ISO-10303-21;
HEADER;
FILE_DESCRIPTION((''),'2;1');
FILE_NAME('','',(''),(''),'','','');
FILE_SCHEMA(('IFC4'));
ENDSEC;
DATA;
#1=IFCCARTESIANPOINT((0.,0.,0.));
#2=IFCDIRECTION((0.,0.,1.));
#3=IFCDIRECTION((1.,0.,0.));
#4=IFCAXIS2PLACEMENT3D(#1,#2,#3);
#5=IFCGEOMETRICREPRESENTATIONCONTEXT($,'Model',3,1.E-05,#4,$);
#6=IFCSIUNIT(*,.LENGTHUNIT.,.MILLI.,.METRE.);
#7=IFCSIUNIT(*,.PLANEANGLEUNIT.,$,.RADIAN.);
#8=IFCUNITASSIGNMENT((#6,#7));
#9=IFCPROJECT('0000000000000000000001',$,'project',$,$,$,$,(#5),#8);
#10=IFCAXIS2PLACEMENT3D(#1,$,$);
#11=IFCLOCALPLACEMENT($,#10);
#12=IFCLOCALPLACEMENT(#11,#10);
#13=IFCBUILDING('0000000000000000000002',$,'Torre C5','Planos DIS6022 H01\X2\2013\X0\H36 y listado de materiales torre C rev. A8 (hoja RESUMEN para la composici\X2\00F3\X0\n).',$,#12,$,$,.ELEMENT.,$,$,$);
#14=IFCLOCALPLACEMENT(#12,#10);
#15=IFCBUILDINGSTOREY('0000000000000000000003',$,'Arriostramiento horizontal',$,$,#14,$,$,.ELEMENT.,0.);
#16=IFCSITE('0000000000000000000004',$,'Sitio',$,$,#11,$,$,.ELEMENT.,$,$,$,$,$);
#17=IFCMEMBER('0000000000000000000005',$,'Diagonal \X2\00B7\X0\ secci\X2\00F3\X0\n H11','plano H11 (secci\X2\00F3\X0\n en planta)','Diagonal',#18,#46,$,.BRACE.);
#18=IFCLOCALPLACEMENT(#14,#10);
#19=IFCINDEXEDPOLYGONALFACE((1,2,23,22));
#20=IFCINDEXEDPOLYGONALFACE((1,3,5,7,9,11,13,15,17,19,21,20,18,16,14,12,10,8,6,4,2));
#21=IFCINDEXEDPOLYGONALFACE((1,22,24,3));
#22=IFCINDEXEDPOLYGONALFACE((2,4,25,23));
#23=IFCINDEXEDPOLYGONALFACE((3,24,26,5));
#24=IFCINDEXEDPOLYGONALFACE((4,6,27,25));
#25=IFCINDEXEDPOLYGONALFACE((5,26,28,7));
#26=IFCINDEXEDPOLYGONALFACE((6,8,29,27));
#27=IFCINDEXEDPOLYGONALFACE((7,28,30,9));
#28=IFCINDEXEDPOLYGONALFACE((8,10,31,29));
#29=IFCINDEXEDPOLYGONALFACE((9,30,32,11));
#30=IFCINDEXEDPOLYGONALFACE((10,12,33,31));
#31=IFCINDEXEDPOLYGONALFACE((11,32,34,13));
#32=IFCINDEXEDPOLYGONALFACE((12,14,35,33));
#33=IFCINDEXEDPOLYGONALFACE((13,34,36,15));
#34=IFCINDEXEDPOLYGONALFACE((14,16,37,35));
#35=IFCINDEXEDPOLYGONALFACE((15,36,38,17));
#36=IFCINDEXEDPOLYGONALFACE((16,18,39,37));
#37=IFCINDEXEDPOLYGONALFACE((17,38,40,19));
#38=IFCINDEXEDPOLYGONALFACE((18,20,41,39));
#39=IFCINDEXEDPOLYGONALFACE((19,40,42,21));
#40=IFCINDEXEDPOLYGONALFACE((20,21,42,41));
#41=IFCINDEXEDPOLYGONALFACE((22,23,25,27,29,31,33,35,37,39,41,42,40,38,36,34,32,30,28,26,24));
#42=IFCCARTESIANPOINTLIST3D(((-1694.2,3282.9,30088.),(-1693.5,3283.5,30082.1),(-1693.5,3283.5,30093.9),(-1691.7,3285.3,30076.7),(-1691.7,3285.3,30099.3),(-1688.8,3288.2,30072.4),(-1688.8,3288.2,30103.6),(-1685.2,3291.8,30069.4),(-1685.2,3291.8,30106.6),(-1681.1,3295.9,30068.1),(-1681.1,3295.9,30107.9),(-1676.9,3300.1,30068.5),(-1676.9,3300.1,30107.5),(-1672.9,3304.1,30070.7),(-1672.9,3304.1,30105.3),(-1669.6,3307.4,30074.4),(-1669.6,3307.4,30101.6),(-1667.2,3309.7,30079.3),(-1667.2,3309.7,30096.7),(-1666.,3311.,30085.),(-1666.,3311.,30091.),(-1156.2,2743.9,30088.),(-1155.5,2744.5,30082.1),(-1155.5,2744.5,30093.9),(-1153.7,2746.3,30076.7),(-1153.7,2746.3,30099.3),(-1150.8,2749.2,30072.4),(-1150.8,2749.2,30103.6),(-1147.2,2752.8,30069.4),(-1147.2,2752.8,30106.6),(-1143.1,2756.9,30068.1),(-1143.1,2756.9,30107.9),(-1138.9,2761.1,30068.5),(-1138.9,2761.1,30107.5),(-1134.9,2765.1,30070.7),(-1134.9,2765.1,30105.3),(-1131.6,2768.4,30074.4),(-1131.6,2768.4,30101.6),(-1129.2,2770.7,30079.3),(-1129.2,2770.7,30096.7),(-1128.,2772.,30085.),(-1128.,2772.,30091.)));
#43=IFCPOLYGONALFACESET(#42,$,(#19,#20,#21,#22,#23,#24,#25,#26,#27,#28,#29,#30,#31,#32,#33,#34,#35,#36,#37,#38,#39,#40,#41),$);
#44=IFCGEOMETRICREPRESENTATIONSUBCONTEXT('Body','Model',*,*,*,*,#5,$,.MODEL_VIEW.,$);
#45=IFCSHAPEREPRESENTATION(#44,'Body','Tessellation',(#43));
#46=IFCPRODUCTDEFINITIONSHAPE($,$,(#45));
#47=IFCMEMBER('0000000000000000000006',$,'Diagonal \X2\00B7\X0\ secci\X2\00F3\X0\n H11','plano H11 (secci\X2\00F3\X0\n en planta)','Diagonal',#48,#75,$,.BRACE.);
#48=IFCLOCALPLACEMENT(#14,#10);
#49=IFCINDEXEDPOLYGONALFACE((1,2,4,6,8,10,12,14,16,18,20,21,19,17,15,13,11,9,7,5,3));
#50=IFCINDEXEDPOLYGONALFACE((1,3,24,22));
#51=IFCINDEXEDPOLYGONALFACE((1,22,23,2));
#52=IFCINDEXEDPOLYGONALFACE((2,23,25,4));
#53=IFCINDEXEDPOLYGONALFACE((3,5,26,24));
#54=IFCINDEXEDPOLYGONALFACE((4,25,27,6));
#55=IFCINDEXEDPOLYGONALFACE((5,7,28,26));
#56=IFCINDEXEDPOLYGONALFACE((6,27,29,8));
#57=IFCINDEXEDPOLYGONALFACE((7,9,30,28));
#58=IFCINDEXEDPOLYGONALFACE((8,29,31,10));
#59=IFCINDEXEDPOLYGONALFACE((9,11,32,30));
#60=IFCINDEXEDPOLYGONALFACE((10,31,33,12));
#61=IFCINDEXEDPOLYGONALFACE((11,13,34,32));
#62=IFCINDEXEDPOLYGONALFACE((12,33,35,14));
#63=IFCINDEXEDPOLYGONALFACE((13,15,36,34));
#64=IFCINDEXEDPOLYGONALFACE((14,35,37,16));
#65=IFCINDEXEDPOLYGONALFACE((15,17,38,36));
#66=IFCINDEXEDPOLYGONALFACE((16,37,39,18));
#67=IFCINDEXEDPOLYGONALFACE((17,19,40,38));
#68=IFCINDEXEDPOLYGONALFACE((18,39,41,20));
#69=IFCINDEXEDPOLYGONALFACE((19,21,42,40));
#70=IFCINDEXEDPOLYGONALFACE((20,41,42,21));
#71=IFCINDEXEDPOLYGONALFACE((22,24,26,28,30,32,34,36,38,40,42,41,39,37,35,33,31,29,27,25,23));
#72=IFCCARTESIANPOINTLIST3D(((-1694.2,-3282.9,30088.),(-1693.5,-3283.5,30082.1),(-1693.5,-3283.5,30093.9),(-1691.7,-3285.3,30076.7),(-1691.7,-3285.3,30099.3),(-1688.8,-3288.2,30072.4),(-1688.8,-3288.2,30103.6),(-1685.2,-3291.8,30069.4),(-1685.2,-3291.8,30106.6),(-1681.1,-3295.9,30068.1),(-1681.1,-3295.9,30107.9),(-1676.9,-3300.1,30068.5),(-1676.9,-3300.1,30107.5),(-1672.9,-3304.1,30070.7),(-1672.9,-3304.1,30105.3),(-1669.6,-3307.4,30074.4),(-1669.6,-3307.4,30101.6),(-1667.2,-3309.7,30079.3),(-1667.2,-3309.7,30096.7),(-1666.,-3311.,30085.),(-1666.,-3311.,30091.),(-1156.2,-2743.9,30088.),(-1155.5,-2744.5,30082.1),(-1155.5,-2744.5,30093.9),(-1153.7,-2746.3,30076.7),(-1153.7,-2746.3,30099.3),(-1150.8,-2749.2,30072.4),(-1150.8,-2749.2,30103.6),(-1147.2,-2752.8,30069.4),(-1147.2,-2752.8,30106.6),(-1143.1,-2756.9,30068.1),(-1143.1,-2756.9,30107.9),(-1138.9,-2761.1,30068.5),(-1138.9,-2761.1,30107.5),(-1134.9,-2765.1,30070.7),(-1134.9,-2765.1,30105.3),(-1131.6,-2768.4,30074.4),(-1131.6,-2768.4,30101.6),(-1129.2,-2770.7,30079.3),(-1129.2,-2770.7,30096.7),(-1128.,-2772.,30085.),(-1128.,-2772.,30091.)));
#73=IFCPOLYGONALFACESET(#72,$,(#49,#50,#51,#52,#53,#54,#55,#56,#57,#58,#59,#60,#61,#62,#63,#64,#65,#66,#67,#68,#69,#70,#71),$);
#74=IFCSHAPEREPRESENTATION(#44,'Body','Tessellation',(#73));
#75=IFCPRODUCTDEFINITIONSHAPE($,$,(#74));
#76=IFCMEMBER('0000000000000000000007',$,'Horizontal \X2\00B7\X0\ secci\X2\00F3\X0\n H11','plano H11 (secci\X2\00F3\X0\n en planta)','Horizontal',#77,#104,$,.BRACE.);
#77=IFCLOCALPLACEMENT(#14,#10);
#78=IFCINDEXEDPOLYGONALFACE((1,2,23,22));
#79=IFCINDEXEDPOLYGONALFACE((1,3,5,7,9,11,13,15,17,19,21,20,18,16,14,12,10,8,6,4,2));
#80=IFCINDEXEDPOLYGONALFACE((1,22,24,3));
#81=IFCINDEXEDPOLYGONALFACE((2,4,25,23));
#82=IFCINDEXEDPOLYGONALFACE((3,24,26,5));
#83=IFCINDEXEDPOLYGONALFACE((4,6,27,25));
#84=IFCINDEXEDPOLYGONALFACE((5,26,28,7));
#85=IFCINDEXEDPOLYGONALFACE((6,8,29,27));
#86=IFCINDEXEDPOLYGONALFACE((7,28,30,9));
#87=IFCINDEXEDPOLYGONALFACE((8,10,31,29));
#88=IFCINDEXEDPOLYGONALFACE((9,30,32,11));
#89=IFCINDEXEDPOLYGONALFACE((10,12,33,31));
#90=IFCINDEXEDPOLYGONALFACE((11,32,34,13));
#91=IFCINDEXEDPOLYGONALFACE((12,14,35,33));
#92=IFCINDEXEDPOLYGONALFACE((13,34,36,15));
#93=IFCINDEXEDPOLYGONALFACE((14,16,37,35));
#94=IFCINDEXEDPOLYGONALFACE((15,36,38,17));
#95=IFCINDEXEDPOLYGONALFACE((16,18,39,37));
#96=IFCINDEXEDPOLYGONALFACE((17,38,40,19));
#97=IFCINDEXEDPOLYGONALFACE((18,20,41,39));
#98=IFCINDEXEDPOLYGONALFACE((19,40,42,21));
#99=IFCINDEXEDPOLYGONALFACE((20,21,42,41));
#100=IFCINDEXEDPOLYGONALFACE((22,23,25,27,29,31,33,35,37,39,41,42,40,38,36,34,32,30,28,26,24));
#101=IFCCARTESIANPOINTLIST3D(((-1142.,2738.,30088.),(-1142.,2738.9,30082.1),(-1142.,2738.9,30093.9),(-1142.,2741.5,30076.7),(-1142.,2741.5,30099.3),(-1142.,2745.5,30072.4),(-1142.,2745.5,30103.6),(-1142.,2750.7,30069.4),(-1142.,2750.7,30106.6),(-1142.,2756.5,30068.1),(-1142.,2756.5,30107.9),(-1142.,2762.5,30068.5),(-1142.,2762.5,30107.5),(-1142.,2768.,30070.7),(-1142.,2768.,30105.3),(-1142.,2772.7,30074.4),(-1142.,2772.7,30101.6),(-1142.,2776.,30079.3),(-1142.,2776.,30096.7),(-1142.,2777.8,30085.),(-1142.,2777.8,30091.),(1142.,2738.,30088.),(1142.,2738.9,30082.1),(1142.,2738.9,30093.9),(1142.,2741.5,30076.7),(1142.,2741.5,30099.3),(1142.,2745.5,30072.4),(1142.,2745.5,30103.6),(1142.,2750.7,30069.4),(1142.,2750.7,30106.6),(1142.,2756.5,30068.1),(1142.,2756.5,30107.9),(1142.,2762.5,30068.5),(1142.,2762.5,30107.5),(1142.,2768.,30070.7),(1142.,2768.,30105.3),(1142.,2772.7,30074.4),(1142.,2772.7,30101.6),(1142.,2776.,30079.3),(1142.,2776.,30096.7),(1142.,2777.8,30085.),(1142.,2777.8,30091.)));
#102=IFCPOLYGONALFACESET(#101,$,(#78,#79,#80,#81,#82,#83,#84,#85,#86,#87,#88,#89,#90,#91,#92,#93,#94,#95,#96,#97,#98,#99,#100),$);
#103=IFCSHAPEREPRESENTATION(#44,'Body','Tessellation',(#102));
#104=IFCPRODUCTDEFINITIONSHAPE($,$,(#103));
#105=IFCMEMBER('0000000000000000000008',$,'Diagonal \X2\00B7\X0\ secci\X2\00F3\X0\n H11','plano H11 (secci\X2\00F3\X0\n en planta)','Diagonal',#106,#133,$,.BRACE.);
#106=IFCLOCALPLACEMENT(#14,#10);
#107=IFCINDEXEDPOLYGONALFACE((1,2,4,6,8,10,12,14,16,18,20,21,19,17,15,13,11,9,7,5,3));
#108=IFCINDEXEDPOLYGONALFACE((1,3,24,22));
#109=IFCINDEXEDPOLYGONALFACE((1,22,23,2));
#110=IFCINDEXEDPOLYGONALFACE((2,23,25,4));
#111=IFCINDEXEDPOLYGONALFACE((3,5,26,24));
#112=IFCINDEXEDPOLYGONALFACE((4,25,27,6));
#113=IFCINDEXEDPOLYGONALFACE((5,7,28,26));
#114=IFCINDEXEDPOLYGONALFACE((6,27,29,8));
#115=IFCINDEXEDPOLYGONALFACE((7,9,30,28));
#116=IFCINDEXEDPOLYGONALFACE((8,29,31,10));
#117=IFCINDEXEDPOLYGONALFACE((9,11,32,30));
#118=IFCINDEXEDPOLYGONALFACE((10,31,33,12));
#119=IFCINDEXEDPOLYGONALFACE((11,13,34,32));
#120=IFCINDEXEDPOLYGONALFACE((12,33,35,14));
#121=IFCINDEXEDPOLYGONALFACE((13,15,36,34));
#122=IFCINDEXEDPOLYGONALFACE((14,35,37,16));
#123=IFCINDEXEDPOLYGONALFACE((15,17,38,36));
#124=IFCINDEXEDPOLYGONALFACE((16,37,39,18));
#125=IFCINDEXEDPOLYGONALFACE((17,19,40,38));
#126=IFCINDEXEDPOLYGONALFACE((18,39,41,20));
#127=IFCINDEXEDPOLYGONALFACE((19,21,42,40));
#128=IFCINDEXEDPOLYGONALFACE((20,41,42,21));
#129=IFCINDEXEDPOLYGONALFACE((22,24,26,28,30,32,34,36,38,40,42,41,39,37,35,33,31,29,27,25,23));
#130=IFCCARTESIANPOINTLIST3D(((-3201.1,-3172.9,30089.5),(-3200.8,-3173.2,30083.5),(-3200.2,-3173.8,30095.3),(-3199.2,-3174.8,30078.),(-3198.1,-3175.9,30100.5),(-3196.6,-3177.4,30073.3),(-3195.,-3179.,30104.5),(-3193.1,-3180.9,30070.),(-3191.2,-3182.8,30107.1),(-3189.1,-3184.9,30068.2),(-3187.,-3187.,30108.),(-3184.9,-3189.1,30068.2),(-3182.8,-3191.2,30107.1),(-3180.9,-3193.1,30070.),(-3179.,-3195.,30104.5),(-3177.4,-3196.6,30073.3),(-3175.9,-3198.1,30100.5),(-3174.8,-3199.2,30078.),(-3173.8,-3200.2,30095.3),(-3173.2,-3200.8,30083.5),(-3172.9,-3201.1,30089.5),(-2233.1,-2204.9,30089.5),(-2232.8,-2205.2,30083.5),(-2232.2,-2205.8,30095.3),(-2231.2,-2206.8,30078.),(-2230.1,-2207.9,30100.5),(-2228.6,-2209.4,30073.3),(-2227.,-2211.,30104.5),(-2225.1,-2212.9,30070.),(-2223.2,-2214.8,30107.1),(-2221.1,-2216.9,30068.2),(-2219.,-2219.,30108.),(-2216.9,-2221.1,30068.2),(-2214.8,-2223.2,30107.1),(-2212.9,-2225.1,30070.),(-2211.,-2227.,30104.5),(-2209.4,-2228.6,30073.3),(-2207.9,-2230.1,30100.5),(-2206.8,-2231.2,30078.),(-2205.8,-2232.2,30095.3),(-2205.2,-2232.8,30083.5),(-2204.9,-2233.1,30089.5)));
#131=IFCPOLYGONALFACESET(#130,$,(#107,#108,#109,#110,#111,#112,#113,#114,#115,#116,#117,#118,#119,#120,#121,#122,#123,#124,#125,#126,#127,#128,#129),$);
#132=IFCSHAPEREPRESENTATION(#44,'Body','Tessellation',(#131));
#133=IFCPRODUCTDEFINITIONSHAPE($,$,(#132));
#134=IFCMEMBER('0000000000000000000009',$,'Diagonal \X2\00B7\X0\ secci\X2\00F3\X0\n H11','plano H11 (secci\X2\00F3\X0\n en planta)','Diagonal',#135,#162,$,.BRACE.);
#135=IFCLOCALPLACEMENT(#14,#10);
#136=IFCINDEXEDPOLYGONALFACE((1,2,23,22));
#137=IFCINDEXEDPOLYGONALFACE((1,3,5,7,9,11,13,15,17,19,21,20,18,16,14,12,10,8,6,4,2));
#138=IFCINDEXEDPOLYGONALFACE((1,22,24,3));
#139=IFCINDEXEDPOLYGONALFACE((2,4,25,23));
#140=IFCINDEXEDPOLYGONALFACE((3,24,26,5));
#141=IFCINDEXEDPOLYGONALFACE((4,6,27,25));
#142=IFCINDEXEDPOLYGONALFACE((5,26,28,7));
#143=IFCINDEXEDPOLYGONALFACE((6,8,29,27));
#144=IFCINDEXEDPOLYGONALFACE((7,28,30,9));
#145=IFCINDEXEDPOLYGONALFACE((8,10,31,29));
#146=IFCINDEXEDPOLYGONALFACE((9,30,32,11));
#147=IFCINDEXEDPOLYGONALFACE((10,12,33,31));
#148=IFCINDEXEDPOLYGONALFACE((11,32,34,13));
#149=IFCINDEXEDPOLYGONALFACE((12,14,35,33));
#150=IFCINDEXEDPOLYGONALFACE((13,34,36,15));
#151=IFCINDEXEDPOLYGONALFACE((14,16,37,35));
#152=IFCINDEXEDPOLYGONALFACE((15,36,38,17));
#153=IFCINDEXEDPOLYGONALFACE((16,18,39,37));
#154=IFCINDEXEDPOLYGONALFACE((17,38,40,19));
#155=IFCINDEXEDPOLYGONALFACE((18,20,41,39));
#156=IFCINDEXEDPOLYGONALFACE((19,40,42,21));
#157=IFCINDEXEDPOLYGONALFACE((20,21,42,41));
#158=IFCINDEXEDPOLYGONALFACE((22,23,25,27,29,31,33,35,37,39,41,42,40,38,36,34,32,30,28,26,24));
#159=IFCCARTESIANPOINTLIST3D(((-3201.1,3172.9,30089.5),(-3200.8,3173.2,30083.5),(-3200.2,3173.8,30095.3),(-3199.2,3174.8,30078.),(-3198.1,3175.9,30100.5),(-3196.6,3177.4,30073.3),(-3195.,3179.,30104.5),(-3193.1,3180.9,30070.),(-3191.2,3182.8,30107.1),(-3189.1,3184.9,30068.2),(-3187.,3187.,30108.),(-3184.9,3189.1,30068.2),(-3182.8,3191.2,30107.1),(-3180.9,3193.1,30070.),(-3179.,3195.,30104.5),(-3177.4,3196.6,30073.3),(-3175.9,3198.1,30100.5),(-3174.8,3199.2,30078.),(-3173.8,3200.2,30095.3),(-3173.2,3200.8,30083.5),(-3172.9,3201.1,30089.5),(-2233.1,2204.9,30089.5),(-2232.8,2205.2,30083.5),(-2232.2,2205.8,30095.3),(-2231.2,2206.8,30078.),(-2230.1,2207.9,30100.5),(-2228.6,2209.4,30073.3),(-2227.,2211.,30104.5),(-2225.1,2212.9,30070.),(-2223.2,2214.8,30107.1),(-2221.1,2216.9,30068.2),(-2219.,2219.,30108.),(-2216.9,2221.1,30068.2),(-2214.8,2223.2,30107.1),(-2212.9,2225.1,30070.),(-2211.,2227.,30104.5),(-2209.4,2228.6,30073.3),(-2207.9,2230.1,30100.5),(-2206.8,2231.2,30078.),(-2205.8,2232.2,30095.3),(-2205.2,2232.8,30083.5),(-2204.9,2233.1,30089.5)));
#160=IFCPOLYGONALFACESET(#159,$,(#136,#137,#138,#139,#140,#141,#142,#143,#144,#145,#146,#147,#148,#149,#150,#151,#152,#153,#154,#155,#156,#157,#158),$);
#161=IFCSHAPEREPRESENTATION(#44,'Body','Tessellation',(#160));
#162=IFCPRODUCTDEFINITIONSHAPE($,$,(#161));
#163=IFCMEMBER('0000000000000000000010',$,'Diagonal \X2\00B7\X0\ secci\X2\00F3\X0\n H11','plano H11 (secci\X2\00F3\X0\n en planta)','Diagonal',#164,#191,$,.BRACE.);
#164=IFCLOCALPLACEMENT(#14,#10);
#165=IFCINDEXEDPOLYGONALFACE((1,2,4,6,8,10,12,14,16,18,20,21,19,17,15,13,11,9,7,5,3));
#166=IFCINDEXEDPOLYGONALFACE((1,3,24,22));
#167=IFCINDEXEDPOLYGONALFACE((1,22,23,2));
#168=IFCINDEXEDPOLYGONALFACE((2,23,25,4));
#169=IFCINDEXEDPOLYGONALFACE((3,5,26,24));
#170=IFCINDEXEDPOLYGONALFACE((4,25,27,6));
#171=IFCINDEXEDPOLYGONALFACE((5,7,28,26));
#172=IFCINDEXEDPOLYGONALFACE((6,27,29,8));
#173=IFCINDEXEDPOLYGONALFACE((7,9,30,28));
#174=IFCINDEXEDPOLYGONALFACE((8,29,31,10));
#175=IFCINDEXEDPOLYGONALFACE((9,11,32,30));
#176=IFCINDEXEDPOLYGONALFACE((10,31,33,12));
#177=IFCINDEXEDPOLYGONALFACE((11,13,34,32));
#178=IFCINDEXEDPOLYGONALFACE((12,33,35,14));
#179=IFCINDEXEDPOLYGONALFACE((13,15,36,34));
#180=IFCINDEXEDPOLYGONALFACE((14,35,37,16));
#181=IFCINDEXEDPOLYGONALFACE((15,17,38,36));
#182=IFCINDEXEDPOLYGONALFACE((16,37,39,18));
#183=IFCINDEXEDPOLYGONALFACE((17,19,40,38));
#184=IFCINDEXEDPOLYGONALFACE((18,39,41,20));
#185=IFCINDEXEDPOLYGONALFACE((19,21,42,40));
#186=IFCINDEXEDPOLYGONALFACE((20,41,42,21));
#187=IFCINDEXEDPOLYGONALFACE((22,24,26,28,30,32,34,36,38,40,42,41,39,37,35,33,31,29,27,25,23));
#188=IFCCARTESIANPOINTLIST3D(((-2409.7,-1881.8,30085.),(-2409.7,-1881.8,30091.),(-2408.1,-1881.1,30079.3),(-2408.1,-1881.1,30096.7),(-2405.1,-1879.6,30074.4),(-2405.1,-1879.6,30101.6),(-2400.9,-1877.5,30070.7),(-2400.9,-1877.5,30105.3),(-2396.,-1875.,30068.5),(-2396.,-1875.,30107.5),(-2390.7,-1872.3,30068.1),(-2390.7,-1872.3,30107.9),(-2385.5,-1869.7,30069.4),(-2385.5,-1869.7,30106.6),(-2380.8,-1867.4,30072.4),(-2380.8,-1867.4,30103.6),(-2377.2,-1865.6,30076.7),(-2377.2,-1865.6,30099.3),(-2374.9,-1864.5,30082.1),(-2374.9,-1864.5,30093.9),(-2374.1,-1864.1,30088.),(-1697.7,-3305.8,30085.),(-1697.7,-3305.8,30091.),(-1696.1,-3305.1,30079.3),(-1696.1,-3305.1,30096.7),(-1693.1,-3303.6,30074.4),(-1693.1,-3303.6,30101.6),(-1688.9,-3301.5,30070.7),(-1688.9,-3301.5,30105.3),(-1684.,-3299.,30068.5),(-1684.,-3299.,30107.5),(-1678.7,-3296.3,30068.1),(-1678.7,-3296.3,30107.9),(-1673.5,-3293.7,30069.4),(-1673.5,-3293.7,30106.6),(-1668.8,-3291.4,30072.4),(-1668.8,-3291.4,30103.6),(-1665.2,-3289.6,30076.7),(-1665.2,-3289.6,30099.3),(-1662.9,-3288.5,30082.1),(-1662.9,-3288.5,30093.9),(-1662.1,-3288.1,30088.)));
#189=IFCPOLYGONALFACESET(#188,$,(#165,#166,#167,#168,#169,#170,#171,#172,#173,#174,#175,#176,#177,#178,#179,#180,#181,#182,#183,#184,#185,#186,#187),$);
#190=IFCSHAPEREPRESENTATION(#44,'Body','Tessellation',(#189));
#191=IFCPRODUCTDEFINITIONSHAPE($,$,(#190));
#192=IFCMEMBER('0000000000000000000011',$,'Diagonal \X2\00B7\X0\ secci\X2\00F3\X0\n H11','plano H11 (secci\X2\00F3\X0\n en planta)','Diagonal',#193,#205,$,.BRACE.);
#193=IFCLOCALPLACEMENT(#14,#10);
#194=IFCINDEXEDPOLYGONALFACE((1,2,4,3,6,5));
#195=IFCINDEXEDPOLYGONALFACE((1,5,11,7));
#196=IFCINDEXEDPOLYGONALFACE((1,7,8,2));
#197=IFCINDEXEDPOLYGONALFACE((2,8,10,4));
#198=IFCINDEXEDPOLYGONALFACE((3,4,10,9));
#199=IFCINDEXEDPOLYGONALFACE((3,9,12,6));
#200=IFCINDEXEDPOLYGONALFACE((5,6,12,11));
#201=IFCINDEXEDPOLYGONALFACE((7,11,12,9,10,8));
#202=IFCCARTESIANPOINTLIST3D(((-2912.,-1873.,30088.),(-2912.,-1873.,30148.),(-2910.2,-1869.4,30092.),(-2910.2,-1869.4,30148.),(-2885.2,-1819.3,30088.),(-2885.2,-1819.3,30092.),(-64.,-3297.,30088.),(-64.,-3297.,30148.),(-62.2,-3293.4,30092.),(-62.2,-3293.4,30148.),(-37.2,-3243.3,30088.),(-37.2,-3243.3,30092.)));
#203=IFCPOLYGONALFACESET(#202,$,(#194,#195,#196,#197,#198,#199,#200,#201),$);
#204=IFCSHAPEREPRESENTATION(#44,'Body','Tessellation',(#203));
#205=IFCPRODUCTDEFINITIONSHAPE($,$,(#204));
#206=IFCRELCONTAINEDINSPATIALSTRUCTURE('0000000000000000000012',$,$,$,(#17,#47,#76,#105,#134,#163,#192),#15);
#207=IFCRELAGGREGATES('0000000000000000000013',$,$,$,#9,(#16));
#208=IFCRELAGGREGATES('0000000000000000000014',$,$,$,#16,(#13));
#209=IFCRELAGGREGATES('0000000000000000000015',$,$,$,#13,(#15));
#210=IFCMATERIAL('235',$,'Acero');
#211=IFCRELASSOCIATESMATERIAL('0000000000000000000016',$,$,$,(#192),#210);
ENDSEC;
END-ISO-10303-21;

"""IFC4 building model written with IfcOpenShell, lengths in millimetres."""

from ifc_helpers import new_model, si_unit, frame, frame_2d, origin, origin_with_axes, place, context, subcontext, project, spatial, circle, l_section, extrude, material, element, save


model = new_model("IFC4")

# Units and contexts
model_context = context("Model", 3, precision=1e-05, world=origin_with_axes())
body_context = subcontext(model_context, "Body", "Model", "MODEL_VIEW")
ifc_project = project(units=[si_unit("LENGTHUNIT", "METRE", prefix="MILLI"), si_unit("PLANEANGLEUNIT", "RADIAN")], contexts=[model_context])

# Site, building, storey
site_placement = place(None, origin())
site = spatial("IfcSite", under=ifc_project, at=site_placement, Name="Sitio", CompositionType="ELEMENT")
building_placement = place(site_placement, origin())
building = spatial("IfcBuilding", under=site, at=building_placement, Name="Torre C5", Description="Planos DIS6022 H01–H36 y listado de materiales torre C rev. A8 (hoja RESUMEN para la composición).", CompositionType="ELEMENT")
storey_placement = place(building_placement, origin())
storey = spatial("IfcBuildingStorey", under=building, at=storey_placement, Name="Arriostramiento horizontal", CompositionType="ELEMENT", Elevation=0.0)

# Members
for number, where, z_axis, x_axis, name in (
    (1, (-1680.0, 3297.0, 30088.0), (0.70645, -0.707763, 0.0), (-0.707763, -0.70645, 0.0), "Diagonal · sección H11"),
    (2, (-1680.0, -3297.0, 30088.0), (0.70645, 0.707763, 0.0), (-0.707763, 0.70645, 0.0), "Diagonal · sección H11"),
):
    element("IfcMember", number, at=place(storey_placement, frame(where, z_axis=z_axis, x_axis=x_axis)), inside=storey, Name=name, Description="plano H11 (sección en planta)", ObjectType="Diagonal", PredefinedType="BRACE", context=body_context, shape_type="SweptSolid", body=[
        extrude(circle(Radius=20.0), None, (0.0, 0.0, 1.0), 761.6),
    ])
member_1_placement = place(storey_placement, frame((-1142.0, 2758.0, 30088.0), z_axis=(1.0, 0.0, 0.0), x_axis=(0.0, -1.0, 0.0)))
element("IfcMember", 3, at=member_1_placement, inside=storey, Name="Horizontal · sección H11", Description="plano H11 (sección en planta)", ObjectType="Horizontal", PredefinedType="BRACE", context=body_context, shape_type="SweptSolid", body=[
    extrude(circle(Radius=20.0), None, (0.0, 0.0, 1.0), 2284.0),
])
for number, where, z_axis, x_axis, name in (
    (4, (-3187.0, -3187.0, 30088.0), (0.707107, 0.707107, 0.0), (0.0, 0.0, 1.0), "Diagonal · sección H11"),
    (5, (-3187.0, 3187.0, 30088.0), (0.707107, -0.707107, 0.0), (0.0, 0.0, 1.0), "Diagonal · sección H11"),
):
    element("IfcMember", number, at=place(storey_placement, frame(where, z_axis=z_axis, x_axis=x_axis)), inside=storey, Name=name, Description="plano H11 (sección en planta)", ObjectType="Diagonal", PredefinedType="BRACE", context=body_context, shape_type="SweptSolid", body=[
        extrude(circle(Radius=20.0), None, (0.0, 0.0, 1.0), 1369.0),
    ])
member_2_placement = place(storey_placement, frame((-2392.0, -1873.0, 30088.0), z_axis=(0.447214, -0.894427, 0.0), x_axis=(0.894427, 0.447214, 0.0)))
element("IfcMember", 6, at=member_2_placement, inside=storey, Name="Diagonal · sección H11", Description="plano H11 (sección en planta)", ObjectType="Diagonal", PredefinedType="BRACE", context=body_context, shape_type="SweptSolid", body=[
    extrude(circle(Radius=20.0), None, (0.0, 0.0, 1.0), 1592.1),
])
ifc_material = material(Name="235", Category="Acero")
member_3_placement = place(storey_placement, frame((-2912.0, -1873.0, 30088.0), z_axis=(0.894427, -0.447214, 0.0), x_axis=(0.447214, 0.894427, 0.0)))
element("IfcMember", 7, at=member_3_placement, inside=storey, material=ifc_material, Name="Diagonal · sección H11", Description="plano H11 (sección en planta)", ObjectType="Diagonal", PredefinedType="BRACE", context=body_context, shape_type="SweptSolid", body=[
    extrude(l_section(Depth=60.0, Width=60.0, Thickness=4.0, at=frame_2d((30.0, 30.0))), None, (0.0, 0.0, 1.0), 3184.2),
])

save(model, "model.ifc")
